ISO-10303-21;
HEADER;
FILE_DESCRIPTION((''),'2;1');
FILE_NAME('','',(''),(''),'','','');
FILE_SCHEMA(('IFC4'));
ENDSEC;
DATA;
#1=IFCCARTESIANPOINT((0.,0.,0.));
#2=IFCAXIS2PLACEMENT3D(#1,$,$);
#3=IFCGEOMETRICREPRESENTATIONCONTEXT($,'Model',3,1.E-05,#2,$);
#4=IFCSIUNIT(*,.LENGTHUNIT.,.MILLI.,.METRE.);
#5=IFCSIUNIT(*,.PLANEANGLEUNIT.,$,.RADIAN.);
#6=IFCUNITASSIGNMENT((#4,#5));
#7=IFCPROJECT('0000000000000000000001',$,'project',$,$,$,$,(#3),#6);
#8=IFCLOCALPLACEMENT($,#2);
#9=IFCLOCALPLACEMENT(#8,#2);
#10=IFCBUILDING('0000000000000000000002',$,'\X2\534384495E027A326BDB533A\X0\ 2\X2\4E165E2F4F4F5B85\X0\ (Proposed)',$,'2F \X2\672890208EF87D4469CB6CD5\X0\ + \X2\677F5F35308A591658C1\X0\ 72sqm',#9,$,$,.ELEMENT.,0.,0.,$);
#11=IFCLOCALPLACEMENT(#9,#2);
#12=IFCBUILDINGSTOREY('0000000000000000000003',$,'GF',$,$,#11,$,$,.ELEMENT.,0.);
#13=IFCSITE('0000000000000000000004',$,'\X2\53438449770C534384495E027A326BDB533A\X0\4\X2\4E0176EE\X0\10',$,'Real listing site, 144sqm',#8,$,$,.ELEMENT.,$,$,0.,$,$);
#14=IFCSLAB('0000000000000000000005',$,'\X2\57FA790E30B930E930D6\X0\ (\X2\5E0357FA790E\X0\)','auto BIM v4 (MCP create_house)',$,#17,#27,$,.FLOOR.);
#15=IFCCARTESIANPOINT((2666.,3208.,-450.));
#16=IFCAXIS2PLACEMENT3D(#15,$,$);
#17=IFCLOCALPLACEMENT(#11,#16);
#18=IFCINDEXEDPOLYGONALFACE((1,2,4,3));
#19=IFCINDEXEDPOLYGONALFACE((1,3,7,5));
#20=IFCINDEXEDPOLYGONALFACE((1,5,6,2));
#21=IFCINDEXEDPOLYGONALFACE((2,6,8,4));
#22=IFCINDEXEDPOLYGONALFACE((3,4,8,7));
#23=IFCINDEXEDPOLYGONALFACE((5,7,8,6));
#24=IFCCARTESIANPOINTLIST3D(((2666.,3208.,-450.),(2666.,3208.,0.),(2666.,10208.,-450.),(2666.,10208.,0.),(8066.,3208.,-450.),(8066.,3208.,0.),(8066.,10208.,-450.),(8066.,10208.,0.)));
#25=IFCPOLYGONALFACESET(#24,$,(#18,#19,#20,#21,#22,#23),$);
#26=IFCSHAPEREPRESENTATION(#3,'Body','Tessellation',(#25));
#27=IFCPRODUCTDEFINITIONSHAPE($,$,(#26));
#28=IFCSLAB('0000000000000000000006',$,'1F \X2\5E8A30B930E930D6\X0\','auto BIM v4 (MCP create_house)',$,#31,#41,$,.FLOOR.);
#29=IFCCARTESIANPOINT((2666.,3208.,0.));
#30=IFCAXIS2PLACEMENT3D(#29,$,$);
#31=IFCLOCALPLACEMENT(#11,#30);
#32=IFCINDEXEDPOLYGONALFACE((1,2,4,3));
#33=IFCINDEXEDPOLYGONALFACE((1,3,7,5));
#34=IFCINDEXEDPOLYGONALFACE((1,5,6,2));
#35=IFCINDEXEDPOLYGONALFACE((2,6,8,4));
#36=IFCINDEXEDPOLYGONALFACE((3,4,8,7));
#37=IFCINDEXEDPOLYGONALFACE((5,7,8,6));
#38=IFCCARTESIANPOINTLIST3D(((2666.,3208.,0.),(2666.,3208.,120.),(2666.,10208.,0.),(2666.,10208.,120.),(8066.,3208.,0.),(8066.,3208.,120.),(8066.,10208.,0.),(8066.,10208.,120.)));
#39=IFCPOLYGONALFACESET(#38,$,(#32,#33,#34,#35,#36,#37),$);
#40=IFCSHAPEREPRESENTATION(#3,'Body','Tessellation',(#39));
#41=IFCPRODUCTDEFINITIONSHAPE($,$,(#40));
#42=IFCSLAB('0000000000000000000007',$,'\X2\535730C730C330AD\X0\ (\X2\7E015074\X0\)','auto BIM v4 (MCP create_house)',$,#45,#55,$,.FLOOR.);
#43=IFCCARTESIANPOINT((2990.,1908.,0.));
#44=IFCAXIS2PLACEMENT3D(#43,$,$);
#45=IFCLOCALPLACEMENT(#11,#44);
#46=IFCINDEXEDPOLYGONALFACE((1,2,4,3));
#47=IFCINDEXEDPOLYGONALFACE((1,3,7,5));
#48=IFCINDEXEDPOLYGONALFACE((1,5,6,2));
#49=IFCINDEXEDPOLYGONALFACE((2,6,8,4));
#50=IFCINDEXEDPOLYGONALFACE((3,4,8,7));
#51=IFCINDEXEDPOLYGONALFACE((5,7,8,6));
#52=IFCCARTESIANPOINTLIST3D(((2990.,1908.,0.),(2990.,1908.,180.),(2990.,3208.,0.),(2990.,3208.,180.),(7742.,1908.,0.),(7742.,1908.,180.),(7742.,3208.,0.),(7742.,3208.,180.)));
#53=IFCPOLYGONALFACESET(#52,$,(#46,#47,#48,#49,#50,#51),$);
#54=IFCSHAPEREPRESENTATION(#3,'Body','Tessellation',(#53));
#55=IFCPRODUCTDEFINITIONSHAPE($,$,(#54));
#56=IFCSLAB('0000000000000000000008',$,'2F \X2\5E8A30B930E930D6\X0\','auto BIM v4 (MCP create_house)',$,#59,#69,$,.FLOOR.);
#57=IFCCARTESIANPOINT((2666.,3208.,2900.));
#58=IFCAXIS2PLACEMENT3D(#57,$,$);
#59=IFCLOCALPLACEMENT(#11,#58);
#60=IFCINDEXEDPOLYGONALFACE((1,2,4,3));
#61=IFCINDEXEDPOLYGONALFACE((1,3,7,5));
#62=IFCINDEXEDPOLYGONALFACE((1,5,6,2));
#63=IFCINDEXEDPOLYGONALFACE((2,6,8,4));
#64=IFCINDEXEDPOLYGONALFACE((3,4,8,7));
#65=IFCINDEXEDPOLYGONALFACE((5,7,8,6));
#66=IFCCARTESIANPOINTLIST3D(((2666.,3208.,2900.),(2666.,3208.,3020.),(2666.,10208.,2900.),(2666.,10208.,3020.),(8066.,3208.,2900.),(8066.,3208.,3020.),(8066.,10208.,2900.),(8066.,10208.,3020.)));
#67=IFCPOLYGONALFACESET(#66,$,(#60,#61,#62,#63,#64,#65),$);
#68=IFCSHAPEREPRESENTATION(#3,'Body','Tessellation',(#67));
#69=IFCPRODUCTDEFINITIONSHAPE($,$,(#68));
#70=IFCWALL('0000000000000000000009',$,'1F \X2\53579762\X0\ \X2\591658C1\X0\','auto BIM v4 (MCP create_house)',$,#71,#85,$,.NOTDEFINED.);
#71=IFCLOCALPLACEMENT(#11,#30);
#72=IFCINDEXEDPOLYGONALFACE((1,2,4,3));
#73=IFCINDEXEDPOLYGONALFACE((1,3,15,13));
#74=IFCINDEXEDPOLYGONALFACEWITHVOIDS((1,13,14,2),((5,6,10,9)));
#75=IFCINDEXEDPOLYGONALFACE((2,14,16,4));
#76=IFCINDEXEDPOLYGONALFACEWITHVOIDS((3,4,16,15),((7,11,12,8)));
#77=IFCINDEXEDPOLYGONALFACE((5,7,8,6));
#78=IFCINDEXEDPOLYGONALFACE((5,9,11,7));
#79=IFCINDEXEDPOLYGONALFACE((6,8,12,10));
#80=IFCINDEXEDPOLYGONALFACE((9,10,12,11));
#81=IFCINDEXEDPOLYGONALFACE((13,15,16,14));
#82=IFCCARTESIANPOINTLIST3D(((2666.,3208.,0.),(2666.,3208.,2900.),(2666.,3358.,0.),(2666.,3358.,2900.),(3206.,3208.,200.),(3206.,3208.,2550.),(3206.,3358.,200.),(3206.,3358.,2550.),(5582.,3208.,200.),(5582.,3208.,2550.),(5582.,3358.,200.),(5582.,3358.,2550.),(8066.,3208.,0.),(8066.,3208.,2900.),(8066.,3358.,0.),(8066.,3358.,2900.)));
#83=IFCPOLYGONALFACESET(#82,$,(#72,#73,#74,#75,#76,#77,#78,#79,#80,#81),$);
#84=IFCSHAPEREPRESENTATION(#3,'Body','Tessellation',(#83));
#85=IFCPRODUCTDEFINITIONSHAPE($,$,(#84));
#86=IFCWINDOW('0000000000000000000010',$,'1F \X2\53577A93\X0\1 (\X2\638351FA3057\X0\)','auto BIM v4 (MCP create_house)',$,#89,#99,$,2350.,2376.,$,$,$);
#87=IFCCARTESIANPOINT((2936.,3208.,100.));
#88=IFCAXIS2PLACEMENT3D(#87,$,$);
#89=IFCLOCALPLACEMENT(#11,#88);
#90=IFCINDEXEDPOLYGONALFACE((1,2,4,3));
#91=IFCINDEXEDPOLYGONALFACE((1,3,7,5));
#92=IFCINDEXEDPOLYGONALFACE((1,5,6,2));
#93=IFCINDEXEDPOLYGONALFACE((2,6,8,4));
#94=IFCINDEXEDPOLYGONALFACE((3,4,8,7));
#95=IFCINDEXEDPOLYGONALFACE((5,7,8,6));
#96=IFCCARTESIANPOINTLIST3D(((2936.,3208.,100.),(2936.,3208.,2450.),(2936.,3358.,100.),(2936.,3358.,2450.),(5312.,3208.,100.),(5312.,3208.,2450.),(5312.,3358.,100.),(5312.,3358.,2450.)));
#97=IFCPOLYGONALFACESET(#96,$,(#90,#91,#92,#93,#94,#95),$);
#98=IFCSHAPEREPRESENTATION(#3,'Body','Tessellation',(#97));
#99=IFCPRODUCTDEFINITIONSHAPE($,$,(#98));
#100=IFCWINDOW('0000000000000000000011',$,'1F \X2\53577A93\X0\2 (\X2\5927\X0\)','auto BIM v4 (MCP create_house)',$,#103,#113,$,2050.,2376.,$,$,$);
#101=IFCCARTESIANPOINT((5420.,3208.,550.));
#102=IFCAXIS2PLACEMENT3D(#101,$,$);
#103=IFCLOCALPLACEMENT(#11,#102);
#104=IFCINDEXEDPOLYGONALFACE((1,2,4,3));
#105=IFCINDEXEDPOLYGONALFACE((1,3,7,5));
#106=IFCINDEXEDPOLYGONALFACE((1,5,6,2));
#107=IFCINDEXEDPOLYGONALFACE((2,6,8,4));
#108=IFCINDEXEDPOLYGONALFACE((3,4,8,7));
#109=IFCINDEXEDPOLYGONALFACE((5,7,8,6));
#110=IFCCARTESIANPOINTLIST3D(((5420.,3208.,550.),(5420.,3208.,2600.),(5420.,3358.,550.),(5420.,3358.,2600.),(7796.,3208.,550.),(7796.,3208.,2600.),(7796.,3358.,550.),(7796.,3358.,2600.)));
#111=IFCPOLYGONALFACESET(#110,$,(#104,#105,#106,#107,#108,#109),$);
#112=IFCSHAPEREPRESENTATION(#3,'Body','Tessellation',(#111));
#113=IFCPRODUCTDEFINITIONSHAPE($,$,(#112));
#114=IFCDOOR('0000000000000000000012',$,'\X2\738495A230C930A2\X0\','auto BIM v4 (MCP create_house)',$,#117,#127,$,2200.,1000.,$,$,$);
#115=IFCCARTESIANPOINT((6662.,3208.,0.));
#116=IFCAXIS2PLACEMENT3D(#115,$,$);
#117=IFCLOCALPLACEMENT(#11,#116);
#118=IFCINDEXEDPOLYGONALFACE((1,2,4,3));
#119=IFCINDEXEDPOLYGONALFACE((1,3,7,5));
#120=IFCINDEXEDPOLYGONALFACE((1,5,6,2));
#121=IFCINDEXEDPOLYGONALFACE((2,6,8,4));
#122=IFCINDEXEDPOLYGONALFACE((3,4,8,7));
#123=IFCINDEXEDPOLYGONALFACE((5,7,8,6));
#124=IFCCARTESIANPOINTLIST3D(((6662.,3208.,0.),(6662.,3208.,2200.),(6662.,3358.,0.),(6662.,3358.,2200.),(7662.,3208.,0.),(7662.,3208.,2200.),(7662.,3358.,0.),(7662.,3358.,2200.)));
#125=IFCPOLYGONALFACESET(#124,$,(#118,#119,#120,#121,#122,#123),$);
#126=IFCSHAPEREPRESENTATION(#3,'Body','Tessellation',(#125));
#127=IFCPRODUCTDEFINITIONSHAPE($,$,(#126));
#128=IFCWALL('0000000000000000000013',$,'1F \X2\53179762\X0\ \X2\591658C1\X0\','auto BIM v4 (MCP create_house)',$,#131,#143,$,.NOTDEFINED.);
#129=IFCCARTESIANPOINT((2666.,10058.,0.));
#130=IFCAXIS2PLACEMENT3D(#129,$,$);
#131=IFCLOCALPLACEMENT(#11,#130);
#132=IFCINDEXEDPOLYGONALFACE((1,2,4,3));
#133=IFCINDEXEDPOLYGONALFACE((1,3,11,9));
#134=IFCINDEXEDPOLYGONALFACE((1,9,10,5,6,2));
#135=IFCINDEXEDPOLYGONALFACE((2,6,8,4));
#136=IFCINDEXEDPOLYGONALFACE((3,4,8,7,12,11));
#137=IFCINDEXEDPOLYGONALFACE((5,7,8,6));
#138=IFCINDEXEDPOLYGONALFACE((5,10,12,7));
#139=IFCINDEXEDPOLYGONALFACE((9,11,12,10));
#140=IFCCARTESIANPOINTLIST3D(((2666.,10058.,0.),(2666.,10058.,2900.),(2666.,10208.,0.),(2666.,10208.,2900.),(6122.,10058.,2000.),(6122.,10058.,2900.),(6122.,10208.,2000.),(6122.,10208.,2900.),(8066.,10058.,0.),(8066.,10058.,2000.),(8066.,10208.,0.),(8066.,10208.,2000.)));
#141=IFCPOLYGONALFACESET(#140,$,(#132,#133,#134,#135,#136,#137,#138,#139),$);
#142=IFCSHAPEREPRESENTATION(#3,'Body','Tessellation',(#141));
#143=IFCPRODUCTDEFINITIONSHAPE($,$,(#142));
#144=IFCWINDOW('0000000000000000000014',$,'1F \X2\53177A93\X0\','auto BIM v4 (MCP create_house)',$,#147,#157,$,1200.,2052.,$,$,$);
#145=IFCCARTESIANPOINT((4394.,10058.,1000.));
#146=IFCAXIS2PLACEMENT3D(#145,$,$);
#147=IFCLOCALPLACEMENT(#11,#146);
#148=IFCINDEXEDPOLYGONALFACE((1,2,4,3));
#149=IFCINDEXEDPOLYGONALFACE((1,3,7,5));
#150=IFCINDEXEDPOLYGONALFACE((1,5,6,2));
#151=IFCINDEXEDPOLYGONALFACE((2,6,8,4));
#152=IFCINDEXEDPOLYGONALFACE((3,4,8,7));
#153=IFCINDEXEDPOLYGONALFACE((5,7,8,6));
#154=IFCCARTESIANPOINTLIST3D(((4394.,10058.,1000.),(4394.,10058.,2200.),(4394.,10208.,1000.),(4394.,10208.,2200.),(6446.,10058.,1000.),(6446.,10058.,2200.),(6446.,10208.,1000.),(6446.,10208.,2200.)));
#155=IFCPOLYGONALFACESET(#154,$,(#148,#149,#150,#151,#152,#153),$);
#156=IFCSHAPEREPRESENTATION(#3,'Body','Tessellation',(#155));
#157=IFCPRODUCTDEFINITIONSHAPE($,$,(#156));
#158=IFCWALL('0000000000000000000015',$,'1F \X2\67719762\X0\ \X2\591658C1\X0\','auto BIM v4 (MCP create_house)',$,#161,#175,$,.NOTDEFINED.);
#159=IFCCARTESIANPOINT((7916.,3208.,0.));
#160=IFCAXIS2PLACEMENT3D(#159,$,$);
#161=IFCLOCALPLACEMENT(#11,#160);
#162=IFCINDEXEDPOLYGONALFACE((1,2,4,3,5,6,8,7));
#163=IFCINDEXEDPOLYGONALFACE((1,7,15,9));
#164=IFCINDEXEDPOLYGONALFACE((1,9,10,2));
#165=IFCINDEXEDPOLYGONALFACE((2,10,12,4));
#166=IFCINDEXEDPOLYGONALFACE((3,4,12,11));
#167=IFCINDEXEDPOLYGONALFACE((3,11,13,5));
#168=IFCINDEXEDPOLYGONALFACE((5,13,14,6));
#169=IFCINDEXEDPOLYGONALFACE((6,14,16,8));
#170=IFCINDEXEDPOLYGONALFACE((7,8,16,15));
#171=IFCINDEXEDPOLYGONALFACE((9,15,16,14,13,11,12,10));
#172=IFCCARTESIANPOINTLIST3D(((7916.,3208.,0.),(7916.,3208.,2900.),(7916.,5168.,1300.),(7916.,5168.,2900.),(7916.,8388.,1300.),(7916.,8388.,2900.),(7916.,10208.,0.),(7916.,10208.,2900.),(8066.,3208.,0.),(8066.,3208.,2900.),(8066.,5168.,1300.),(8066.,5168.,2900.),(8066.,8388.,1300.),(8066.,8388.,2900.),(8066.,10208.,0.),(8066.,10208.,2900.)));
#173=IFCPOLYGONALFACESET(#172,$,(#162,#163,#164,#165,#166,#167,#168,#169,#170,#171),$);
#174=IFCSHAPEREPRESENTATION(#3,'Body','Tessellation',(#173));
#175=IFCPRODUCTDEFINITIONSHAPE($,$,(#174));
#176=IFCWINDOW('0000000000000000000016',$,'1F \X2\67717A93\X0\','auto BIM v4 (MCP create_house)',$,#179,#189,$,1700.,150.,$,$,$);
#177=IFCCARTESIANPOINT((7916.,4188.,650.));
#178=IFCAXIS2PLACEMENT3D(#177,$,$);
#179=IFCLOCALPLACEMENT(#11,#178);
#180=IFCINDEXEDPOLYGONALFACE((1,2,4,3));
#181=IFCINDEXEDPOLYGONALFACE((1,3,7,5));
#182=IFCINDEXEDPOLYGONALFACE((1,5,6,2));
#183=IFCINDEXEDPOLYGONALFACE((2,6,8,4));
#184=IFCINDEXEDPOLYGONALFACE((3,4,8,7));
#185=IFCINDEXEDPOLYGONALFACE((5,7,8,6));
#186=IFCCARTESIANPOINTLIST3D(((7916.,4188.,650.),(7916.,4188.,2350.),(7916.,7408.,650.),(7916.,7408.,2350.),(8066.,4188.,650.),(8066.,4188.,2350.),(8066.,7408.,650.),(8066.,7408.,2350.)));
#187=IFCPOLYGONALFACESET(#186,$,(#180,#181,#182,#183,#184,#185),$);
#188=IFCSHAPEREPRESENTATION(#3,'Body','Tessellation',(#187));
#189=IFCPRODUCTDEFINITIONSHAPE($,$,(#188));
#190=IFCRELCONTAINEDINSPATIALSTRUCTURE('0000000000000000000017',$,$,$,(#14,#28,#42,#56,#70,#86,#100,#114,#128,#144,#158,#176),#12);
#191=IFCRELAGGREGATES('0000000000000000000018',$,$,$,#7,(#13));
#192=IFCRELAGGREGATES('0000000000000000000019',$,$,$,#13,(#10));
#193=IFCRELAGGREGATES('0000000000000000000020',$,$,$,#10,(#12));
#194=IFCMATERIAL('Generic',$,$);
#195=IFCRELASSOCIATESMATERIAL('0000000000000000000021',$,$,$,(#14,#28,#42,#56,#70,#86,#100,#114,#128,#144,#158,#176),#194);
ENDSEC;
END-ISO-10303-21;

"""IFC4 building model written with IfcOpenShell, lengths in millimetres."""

from ifc_helpers import new_model, si_unit, frame, frame_2d, origin, place, context, project, spatial, rectangle, extrude, material, element, fill, save


model = new_model("IFC4")

# Units and contexts
model_context = context("Model", 3, precision=1e-05, world=origin())
ifc_project = project(units=[si_unit("LENGTHUNIT", "METRE", prefix="MILLI"), si_unit("PLANEANGLEUNIT", "RADIAN")], contexts=[model_context])

# Site, building, storey
site_placement = place(None, origin())
site = spatial("IfcSite", under=ifc_project, at=site_placement, Name="千葉県千葉市稲毛区4丁目10", ObjectType="Real listing site, 144sqm", CompositionType="ELEMENT", RefElevation=0.0)
building_placement = place(site_placement, origin())
building = spatial("IfcBuilding", under=site, at=building_placement, Name="千葉市稲毛区 2世帯住宅 (Proposed)", ObjectType="2F 木造軸組構法 + 板張り外壁 72sqm", CompositionType="ELEMENT", ElevationOfRefHeight=0.0, ElevationOfTerrain=0.0)
storey_placement = place(building_placement, origin())
storey = spatial("IfcBuildingStorey", under=building, at=storey_placement, Name="GF", CompositionType="ELEMENT", Elevation=0.0)

# Slabs
ifc_material = material(Name="Generic")
slab_1_placement = place(storey_placement, frame((2666.0, 3208.0, -450.0)))
element("IfcSlab", 1, at=slab_1_placement, inside=storey, material=ifc_material, Name="基礎スラブ (布基礎)", Description="auto BIM v4 (MCP create_house)", PredefinedType="FLOOR", context=model_context, shape_type="SweptSolid", body=[
    extrude(rectangle(XDim=5400.0, YDim=7000.0, at=frame_2d((2700.0, 3500.0))), frame((2666.0, 3208.0, -450.0)), (0.0, 0.0, 1.0), 450.0),
])
slab_2_placement = place(storey_placement, frame((2666.0, 3208.0, 0.0)))
element("IfcSlab", 2, at=slab_2_placement, inside=storey, material=ifc_material, Name="1F 床スラブ", Description="auto BIM v4 (MCP create_house)", PredefinedType="FLOOR", context=model_context, shape_type="SweptSolid", body=[
    extrude(rectangle(XDim=5400.0, YDim=7000.0, at=frame_2d((2700.0, 3500.0))), frame((2666.0, 3208.0, 0.0)), (0.0, 0.0, 1.0), 120.0),
])
slab_3_placement = place(storey_placement, frame((2990.0, 1908.0, 0.0)))
element("IfcSlab", 3, at=slab_3_placement, inside=storey, material=ifc_material, Name="南デッキ (縁側)", Description="auto BIM v4 (MCP create_house)", PredefinedType="FLOOR", context=model_context, shape_type="SweptSolid", body=[
    extrude(rectangle(XDim=4752.0, YDim=1300.0, at=frame_2d((2376.0, 650.0))), frame((2990.0, 1908.0, 0.0)), (0.0, 0.0, 1.0), 180.0),
])
slab_4_placement = place(storey_placement, frame((2666.0, 3208.0, 2900.0)))
element("IfcSlab", 4, at=slab_4_placement, inside=storey, material=ifc_material, Name="2F 床スラブ", Description="auto BIM v4 (MCP create_house)", PredefinedType="FLOOR", context=model_context, shape_type="SweptSolid", body=[
    extrude(rectangle(XDim=5400.0, YDim=7000.0, at=frame_2d((2700.0, 3500.0))), frame((2666.0, 3208.0, 2900.0)), (0.0, 0.0, 1.0), 120.0),
])

# Wall, openings, windows, door
wall_1_placement = place(storey_placement, frame((2666.0, 3208.0, 0.0)))
wall_1 = element("IfcWall", 5, at=wall_1_placement, inside=storey, material=ifc_material, Name="1F 南面 外壁", Description="auto BIM v4 (MCP create_house)", PredefinedType="NOTDEFINED", context=model_context, shape_type="SweptSolid", body=[
    extrude(rectangle(XDim=5400.0, YDim=150.0, at=frame_2d((2700.0, 75.0))), frame((2666.0, 3208.0, 0.0)), (0.0, 0.0, 1.0), 2900.0),
])
opening_1_placement = place(storey_placement, frame((2936.0, 3208.0, 100.0)))
opening_1 = element("IfcOpeningElement", 6, at=opening_1_placement, cuts=wall_1, PredefinedType="NOTDEFINED", context=model_context, shape_type="SweptSolid", body=[
    extrude(rectangle(XDim=2376.0, YDim=150.0, at=frame_2d((1188.0, 75.0))), frame((2936.0, 3208.0, 100.0)), (0.0, 0.0, 1.0), 2350.0),
])
opening_2_placement = place(storey_placement, frame((5420.0, 3208.0, 550.0)))
opening_2 = element("IfcOpeningElement", 7, at=opening_2_placement, cuts=wall_1, PredefinedType="NOTDEFINED", context=model_context, shape_type="SweptSolid", body=[
    extrude(rectangle(XDim=2376.0, YDim=150.0, at=frame_2d((1188.0, 75.0))), frame((5420.0, 3208.0, 550.0)), (0.0, 0.0, 1.0), 2050.0),
])
opening_3_placement = place(storey_placement, frame((6662.0, 3208.0, 0.0)))
opening_3 = element("IfcOpeningElement", 8, at=opening_3_placement, cuts=wall_1, PredefinedType="NOTDEFINED", context=model_context, shape_type="SweptSolid", body=[
    extrude(rectangle(XDim=1000.0, YDim=150.0, at=frame_2d((500.0, 75.0))), frame((6662.0, 3208.0, 0.0)), (0.0, 0.0, 1.0), 2200.0),
])
window_1_placement = place(storey_placement, frame((2936.0, 3208.0, 100.0)))
window_1 = element("IfcWindow", 9, at=window_1_placement, inside=storey, material=ifc_material, Name="1F 南窓1 (掃出し)", Description="auto BIM v4 (MCP create_house)", OverallHeight=2350.0, OverallWidth=2376.0, context=model_context, shape_type="SweptSolid", body=[
    extrude(rectangle(XDim=2376.0, YDim=150.0, at=frame_2d((1188.0, 75.0))), frame((2936.0, 3208.0, 100.0)), (0.0, 0.0, 1.0), 2350.0),
])
fill(opening_1, window_1)
window_2_placement = place(storey_placement, frame((5420.0, 3208.0, 550.0)))
window_2 = element("IfcWindow", 10, at=window_2_placement, inside=storey, material=ifc_material, Name="1F 南窓2 (大)", Description="auto BIM v4 (MCP create_house)", OverallHeight=2050.0, OverallWidth=2376.0, context=model_context, shape_type="SweptSolid", body=[
    extrude(rectangle(XDim=2376.0, YDim=150.0, at=frame_2d((1188.0, 75.0))), frame((5420.0, 3208.0, 550.0)), (0.0, 0.0, 1.0), 2050.0),
])
fill(opening_2, window_2)
door_1_placement = place(storey_placement, frame((6662.0, 3208.0, 0.0)))
door_1 = element("IfcDoor", 11, at=door_1_placement, inside=storey, material=ifc_material, Name="玄関ドア", Description="auto BIM v4 (MCP create_house)", OverallHeight=2200.0, OverallWidth=1000.0, context=model_context, shape_type="SweptSolid", body=[
    extrude(rectangle(XDim=1000.0, YDim=150.0, at=frame_2d((500.0, 75.0))), frame((6662.0, 3208.0, 0.0)), (0.0, 0.0, 1.0), 2200.0),
])
fill(opening_3, door_1)

# Walls, openings, windows
wall_2_placement = place(storey_placement, frame((2666.0, 10058.0, 0.0)))
wall_2 = element("IfcWall", 12, at=wall_2_placement, inside=storey, material=ifc_material, Name="1F 北面 外壁", Description="auto BIM v4 (MCP create_house)", PredefinedType="NOTDEFINED", context=model_context, shape_type="SweptSolid", body=[
    extrude(rectangle(XDim=5400.0, YDim=150.0, at=frame_2d((2700.0, 75.0))), frame((2666.0, 10058.0, 0.0)), (0.0, 0.0, 1.0), 2900.0),
])
opening_4_placement = place(storey_placement, frame((4394.0, 10058.0, 1000.0)))
opening_4 = element("IfcOpeningElement", 13, at=opening_4_placement, cuts=wall_2, PredefinedType="NOTDEFINED", context=model_context, shape_type="SweptSolid", body=[
    extrude(rectangle(XDim=2052.0, YDim=150.0, at=frame_2d((1026.0, 75.0))), frame((4394.0, 10058.0, 1000.0)), (0.0, 0.0, 1.0), 1200.0),
])
window_3_placement = place(storey_placement, frame((4394.0, 10058.0, 1000.0)))
window_3 = element("IfcWindow", 14, at=window_3_placement, inside=storey, material=ifc_material, Name="1F 北窓", Description="auto BIM v4 (MCP create_house)", OverallHeight=1200.0, OverallWidth=2052.0, context=model_context, shape_type="SweptSolid", body=[
    extrude(rectangle(XDim=2052.0, YDim=150.0, at=frame_2d((1026.0, 75.0))), frame((4394.0, 10058.0, 1000.0)), (0.0, 0.0, 1.0), 1200.0),
])
fill(opening_4, window_3)
wall_3_placement = place(storey_placement, frame((7916.0, 3208.0, 0.0)))
wall_3 = element("IfcWall", 15, at=wall_3_placement, inside=storey, material=ifc_material, Name="1F 東面 外壁", Description="auto BIM v4 (MCP create_house)", PredefinedType="NOTDEFINED", context=model_context, shape_type="SweptSolid", body=[
    extrude(rectangle(XDim=150.0, YDim=7000.0, at=frame_2d((75.0, 3500.0))), frame((7916.0, 3208.0, 0.0)), (0.0, 0.0, 1.0), 2900.0),
])
opening_5_placement = place(storey_placement, frame((7916.0, 4188.0, 650.0)))
opening_5 = element("IfcOpeningElement", 16, at=opening_5_placement, cuts=wall_3, PredefinedType="NOTDEFINED", context=model_context, shape_type="SweptSolid", body=[
    extrude(rectangle(XDim=150.0, YDim=3220.0, at=frame_2d((75.0, 1610.0))), frame((7916.0, 4188.0, 650.0)), (0.0, 0.0, 1.0), 1700.0),
])
window_4_placement = place(storey_placement, frame((7916.0, 4188.0, 650.0)))
window_4 = element("IfcWindow", 17, at=window_4_placement, inside=storey, material=ifc_material, Name="1F 東窓", Description="auto BIM v4 (MCP create_house)", OverallHeight=1700.0, OverallWidth=150.0, context=model_context, shape_type="SweptSolid", body=[
    extrude(rectangle(XDim=150.0, YDim=3220.0, at=frame_2d((75.0, 1610.0))), frame((7916.0, 4188.0, 650.0)), (0.0, 0.0, 1.0), 1700.0),
])
fill(opening_5, window_4)

save(model, "model.ifc")
